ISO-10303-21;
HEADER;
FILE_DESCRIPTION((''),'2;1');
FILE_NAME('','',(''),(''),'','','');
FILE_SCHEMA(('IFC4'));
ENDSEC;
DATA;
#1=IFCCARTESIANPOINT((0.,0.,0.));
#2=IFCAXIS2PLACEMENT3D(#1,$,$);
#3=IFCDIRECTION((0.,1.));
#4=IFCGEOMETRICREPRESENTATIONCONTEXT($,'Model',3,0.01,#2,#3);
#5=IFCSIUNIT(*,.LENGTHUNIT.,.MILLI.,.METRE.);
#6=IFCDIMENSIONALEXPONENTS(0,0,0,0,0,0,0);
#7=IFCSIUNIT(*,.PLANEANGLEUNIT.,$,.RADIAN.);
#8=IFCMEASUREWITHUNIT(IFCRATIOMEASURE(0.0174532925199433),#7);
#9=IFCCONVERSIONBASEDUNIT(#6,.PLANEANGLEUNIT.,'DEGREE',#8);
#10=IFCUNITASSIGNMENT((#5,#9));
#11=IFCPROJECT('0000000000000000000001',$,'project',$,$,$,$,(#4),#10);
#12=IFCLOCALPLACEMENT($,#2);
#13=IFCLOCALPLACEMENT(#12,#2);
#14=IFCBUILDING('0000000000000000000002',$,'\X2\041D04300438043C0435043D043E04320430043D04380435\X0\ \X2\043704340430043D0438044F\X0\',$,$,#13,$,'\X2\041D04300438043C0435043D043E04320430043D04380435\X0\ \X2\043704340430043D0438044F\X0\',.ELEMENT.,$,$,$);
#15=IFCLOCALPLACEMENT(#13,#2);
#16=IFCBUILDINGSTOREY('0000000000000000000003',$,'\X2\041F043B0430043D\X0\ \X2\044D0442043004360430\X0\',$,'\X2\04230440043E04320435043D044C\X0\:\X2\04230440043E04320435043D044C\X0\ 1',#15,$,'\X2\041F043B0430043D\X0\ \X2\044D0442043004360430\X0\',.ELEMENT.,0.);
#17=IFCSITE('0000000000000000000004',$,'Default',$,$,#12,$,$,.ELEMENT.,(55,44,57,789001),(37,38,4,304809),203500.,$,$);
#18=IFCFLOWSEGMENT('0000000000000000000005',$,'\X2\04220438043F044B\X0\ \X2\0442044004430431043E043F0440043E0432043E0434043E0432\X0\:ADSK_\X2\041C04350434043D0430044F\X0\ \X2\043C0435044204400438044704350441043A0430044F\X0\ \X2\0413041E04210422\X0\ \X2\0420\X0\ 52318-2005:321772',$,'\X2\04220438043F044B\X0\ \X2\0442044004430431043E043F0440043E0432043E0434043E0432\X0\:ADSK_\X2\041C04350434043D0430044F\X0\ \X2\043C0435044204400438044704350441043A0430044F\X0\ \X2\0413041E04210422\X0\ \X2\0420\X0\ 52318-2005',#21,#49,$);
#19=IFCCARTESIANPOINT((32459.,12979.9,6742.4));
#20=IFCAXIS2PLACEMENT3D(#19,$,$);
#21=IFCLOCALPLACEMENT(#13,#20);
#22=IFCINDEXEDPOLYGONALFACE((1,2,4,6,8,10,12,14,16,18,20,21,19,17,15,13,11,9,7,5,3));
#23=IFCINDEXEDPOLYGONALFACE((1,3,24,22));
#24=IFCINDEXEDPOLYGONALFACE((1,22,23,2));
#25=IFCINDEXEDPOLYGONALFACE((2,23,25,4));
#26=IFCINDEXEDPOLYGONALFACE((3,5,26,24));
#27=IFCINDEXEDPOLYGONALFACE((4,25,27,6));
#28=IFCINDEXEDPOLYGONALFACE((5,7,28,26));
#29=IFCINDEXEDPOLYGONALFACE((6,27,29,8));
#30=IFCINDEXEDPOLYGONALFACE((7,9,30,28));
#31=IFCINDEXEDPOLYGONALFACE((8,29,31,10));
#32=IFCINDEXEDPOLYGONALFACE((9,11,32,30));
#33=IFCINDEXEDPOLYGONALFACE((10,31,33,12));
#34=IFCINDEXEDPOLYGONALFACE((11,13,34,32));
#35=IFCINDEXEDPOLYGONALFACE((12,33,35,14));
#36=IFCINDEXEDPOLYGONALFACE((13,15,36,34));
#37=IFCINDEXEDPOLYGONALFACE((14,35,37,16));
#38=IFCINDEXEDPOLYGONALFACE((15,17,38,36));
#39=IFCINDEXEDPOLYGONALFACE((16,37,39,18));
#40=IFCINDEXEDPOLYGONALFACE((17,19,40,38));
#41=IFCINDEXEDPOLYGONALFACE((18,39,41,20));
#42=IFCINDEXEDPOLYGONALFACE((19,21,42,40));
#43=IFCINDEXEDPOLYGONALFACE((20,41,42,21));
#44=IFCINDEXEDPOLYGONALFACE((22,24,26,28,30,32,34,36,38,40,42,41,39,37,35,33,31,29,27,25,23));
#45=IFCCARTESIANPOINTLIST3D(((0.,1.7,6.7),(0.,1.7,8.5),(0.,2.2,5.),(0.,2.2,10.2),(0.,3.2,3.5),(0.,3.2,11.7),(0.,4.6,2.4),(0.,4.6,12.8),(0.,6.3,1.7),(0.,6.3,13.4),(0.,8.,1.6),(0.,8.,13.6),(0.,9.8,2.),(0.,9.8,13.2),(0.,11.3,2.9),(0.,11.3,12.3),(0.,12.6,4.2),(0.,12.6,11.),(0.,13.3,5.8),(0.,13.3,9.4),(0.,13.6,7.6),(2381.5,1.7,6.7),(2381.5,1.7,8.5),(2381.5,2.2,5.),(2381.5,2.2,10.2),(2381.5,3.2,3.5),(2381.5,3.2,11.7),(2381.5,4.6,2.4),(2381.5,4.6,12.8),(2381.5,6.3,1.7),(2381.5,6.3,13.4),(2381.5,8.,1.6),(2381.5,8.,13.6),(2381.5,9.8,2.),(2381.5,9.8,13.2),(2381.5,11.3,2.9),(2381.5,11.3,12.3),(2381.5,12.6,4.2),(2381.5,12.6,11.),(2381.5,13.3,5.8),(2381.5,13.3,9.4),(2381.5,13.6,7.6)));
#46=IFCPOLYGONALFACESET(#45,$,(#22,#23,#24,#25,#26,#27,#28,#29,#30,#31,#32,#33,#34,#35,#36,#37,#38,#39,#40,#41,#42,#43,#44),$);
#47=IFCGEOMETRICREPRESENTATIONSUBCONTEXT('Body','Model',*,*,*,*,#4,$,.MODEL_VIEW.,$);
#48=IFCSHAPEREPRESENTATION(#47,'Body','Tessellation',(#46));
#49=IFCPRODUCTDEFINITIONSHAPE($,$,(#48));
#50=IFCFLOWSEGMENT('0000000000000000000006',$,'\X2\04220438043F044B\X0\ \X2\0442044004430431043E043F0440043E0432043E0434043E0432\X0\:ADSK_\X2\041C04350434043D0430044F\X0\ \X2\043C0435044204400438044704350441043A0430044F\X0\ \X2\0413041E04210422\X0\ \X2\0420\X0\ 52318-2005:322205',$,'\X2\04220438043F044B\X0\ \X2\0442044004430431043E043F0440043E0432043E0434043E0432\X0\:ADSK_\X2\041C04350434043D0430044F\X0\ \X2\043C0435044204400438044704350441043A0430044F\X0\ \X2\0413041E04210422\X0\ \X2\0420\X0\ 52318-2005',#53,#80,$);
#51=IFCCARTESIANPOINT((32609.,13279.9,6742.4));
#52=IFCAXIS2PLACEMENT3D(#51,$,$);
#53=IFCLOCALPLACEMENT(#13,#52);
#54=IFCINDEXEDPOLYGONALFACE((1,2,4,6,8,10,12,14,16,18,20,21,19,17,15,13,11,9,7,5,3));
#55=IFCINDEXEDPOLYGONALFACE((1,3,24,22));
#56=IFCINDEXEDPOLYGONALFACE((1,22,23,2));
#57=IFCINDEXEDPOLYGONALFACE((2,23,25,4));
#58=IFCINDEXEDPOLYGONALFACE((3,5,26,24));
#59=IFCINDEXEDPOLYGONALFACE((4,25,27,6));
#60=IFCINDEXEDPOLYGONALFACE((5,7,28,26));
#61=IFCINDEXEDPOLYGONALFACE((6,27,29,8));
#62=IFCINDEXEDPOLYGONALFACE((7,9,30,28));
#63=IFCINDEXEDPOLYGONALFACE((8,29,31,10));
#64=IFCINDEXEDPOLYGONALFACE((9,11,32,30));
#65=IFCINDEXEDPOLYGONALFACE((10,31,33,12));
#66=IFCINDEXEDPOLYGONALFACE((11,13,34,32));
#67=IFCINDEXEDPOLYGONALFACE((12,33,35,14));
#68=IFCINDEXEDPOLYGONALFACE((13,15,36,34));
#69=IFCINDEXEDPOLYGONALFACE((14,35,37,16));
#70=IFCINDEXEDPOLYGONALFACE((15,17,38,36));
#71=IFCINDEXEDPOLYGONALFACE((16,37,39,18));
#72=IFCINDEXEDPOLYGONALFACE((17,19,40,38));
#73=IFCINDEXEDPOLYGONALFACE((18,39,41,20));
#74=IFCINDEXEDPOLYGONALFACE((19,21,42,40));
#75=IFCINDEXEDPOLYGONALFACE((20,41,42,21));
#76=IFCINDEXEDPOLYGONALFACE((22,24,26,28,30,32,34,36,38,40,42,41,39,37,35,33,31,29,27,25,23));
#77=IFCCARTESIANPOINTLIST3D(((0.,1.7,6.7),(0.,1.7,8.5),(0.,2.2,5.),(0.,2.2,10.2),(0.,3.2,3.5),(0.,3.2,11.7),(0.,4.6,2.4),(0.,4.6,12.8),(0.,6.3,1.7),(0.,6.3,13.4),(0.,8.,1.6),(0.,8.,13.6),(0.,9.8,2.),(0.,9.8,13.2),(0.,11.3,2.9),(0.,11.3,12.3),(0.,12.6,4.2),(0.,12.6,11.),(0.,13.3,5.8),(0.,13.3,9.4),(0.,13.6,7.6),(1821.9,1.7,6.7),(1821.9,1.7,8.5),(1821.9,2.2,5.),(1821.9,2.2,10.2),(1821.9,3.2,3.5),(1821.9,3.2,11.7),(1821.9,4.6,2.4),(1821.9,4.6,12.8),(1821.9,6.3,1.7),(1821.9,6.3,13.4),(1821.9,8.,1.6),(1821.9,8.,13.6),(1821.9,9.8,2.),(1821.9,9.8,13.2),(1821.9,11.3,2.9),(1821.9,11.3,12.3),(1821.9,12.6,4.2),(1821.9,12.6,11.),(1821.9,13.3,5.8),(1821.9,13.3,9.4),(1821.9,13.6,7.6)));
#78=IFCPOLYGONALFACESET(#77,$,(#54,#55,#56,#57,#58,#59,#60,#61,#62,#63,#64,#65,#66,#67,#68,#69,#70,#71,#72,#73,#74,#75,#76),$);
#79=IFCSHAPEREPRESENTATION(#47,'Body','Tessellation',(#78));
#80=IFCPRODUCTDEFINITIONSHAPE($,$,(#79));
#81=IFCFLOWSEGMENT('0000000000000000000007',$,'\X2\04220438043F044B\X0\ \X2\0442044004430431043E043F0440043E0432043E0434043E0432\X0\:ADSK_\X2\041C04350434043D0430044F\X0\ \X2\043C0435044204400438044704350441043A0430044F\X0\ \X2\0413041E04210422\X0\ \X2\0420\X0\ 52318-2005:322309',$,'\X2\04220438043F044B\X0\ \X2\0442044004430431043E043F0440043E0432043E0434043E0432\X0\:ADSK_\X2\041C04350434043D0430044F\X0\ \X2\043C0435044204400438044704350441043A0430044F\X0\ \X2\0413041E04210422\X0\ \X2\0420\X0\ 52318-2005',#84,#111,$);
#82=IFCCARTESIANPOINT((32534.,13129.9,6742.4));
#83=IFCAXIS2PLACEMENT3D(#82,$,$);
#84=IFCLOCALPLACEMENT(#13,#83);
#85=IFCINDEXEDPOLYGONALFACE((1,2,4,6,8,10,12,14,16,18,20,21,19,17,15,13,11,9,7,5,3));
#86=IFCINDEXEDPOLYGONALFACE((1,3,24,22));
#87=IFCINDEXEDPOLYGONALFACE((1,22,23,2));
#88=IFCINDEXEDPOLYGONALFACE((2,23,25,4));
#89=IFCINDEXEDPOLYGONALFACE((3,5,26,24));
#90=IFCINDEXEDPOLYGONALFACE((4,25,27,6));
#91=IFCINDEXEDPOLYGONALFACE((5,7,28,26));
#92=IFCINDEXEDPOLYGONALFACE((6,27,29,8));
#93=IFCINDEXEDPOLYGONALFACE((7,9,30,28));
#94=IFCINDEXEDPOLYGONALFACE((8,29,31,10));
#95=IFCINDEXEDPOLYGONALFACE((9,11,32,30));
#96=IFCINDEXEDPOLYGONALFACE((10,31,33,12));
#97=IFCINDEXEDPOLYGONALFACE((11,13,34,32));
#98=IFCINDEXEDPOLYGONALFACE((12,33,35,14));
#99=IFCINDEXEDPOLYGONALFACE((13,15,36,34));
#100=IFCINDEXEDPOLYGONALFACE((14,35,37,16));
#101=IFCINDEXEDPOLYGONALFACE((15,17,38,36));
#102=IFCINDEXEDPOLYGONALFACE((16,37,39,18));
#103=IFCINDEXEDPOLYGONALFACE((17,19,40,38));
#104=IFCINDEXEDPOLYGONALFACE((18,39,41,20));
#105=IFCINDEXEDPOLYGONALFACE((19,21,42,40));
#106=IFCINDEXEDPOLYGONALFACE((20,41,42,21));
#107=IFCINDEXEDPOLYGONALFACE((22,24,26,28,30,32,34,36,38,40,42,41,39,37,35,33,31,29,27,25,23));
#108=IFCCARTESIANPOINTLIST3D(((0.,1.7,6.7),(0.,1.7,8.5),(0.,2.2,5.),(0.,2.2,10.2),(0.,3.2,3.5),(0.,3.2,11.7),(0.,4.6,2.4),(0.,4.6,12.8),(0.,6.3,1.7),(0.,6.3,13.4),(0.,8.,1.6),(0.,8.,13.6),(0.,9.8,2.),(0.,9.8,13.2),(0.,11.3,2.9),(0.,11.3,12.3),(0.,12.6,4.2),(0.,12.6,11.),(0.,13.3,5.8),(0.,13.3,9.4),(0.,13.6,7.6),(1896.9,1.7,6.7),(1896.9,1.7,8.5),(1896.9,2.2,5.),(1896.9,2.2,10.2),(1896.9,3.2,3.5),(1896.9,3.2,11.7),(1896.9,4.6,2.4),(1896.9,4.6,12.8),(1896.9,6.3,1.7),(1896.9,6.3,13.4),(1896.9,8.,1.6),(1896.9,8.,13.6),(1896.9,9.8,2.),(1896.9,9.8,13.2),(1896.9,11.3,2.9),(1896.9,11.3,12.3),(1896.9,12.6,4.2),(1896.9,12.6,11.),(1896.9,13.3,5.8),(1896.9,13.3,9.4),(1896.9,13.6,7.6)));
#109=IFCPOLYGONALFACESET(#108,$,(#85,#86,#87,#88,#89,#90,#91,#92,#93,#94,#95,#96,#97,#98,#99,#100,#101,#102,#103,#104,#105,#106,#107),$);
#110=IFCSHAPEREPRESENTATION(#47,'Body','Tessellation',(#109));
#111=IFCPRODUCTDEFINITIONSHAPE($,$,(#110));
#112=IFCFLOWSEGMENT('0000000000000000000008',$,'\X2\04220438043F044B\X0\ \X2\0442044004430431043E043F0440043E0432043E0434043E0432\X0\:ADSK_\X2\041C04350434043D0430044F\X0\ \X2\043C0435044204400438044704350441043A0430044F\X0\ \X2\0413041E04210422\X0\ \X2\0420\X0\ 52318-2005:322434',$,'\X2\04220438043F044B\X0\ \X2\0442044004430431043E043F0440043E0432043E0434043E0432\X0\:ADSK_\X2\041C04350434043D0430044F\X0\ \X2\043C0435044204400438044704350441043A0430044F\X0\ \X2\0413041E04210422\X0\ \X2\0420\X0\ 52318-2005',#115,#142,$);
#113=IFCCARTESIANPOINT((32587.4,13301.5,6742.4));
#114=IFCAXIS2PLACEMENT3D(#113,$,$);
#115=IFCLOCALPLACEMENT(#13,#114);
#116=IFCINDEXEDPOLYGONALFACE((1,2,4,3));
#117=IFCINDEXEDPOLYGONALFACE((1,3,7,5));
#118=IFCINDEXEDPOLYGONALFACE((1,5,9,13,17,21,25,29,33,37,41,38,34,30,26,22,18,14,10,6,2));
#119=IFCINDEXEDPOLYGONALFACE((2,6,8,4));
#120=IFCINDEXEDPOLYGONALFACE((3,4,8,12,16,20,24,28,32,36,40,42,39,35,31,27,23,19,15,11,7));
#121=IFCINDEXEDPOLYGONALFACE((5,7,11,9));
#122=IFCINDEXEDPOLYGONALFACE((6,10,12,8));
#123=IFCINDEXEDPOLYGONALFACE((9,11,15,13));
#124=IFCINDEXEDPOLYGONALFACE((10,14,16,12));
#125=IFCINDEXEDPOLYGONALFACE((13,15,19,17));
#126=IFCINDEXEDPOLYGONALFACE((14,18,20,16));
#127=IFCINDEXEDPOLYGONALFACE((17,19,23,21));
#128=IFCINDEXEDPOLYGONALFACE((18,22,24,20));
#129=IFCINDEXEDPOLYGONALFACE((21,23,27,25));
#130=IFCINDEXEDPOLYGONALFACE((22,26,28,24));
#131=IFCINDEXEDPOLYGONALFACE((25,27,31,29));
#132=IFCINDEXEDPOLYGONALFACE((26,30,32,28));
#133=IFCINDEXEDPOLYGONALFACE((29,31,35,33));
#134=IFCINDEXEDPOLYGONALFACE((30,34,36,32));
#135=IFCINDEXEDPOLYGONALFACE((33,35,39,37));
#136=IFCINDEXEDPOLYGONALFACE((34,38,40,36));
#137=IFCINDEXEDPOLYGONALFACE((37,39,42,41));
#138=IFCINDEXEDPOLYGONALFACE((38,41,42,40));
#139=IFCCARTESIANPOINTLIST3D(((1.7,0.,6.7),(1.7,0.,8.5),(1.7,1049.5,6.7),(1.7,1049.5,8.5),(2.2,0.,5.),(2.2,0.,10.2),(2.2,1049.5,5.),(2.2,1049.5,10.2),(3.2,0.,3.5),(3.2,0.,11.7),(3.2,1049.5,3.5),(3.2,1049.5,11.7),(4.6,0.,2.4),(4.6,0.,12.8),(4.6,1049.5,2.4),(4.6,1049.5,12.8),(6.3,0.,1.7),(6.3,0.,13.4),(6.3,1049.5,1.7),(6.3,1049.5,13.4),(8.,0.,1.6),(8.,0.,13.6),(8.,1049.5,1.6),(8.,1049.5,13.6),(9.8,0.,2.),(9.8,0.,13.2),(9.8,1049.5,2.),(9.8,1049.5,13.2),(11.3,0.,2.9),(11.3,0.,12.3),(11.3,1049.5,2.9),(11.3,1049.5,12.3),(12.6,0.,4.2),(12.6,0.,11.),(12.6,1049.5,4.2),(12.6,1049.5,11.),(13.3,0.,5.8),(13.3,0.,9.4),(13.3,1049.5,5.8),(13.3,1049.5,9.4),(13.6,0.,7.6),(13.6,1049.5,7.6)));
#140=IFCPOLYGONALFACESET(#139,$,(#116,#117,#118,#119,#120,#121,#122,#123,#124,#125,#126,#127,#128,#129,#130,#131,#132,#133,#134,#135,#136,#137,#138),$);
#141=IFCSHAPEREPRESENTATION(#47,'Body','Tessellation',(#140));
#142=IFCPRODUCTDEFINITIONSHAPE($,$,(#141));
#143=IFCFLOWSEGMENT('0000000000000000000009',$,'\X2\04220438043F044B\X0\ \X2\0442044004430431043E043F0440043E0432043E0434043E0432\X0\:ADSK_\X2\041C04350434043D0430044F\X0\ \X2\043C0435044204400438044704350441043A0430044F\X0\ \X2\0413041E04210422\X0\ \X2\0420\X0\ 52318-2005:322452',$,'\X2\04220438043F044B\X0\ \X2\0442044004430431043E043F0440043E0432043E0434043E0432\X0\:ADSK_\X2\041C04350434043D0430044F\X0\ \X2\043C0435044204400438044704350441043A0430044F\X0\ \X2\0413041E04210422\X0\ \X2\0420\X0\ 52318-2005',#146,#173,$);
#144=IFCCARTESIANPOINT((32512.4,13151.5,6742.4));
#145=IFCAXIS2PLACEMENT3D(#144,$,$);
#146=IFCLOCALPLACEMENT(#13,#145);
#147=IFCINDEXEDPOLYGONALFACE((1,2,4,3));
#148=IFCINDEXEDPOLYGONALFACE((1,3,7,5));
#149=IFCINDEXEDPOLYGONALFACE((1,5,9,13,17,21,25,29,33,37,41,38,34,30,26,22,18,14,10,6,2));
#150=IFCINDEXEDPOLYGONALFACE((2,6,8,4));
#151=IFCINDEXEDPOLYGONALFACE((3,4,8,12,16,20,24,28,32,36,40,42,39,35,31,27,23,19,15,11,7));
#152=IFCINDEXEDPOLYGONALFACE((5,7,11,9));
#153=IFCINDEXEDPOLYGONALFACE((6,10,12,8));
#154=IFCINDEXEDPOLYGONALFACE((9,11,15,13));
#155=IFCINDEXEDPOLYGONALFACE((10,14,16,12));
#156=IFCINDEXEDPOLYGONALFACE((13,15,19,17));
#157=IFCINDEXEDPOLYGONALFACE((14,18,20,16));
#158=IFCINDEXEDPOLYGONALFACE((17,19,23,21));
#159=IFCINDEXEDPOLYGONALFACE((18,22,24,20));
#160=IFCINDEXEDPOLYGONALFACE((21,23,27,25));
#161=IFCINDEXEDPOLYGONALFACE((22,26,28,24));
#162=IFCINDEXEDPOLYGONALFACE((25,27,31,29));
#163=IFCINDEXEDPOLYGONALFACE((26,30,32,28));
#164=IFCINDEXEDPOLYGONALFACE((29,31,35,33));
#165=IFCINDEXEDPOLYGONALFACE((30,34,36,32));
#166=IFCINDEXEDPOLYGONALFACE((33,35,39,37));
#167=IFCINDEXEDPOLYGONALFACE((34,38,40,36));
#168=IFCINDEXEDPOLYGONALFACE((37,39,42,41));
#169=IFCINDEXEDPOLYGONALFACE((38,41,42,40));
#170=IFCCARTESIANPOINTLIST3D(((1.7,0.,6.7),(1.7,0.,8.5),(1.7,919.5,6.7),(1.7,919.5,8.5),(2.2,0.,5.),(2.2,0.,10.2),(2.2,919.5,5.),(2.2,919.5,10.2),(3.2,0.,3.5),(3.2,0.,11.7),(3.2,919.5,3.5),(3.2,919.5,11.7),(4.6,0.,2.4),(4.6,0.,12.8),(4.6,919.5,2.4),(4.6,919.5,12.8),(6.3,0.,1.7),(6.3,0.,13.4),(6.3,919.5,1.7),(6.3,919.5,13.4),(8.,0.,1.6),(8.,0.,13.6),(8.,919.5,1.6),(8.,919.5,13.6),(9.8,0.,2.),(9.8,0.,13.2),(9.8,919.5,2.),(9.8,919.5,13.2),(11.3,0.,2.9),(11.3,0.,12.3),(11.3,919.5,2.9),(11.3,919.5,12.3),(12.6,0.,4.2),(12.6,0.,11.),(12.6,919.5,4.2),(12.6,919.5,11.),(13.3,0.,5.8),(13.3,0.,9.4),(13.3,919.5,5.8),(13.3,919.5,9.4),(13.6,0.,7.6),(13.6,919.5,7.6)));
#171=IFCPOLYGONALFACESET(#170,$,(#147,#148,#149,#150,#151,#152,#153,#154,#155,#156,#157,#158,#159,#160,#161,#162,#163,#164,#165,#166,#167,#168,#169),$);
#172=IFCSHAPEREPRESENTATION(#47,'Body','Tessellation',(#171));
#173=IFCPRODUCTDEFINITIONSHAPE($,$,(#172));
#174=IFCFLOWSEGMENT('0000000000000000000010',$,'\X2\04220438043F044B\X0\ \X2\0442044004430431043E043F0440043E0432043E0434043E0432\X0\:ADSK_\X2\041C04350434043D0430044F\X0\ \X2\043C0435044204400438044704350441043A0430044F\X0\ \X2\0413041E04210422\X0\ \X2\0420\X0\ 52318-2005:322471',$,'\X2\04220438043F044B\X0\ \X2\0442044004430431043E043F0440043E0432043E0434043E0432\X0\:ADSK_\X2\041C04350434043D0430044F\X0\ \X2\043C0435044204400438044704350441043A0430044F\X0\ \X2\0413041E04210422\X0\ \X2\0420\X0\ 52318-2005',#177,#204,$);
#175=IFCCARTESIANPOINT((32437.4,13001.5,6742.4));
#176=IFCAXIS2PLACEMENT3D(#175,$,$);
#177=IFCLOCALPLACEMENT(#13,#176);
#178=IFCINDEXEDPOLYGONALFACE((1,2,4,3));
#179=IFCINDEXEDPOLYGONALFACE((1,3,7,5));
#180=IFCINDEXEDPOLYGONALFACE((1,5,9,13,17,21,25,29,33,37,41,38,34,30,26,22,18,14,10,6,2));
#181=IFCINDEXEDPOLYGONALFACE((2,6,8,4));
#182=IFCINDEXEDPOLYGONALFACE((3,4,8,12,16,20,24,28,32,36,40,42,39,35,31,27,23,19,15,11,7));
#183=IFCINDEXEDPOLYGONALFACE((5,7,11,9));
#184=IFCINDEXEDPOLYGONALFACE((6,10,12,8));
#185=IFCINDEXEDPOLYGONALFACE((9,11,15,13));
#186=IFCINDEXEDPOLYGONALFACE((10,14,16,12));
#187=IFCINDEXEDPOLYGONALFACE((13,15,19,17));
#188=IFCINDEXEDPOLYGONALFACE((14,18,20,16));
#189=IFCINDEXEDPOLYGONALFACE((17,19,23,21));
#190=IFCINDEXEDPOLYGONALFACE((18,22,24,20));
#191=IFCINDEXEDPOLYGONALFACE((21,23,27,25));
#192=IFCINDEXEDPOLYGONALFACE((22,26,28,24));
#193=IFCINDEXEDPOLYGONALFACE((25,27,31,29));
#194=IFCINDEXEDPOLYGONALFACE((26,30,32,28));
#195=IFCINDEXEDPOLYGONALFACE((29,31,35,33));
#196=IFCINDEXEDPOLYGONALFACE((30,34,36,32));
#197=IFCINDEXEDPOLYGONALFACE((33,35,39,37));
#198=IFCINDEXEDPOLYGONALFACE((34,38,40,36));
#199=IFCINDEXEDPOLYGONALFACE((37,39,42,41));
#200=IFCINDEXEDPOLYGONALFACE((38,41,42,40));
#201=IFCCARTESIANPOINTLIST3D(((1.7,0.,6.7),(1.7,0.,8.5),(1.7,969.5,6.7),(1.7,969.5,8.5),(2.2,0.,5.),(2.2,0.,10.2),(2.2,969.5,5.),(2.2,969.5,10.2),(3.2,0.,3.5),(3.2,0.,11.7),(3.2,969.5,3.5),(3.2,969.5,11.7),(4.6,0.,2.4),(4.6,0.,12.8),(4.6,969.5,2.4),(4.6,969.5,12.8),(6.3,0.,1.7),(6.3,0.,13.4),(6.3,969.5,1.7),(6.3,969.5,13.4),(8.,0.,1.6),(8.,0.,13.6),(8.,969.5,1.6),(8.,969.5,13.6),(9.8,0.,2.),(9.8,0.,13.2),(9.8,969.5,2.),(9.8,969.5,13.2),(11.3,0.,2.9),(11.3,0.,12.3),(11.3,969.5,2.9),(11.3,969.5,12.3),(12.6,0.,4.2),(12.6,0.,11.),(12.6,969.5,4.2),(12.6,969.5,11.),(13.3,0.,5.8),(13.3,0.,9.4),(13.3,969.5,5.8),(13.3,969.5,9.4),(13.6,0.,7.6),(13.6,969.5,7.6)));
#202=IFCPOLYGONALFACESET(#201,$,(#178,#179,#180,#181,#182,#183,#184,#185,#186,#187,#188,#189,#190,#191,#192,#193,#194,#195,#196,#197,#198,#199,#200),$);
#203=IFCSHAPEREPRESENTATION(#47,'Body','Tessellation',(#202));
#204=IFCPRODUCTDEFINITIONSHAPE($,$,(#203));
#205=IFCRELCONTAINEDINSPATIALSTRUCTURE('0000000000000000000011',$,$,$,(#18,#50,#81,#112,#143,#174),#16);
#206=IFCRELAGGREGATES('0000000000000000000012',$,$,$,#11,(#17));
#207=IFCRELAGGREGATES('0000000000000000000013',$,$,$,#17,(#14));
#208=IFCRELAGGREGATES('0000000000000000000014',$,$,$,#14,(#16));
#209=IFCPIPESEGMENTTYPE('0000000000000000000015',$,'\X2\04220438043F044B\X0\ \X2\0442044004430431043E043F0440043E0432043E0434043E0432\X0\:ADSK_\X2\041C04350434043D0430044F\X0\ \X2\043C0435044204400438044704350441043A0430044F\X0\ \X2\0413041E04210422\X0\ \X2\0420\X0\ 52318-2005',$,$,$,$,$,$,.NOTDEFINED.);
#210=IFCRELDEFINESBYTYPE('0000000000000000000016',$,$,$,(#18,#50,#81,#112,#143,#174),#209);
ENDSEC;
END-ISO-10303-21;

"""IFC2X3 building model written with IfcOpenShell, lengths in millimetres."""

from ifc_helpers import new_model, entity, si_unit, converted_unit, direction, frame, frame_2d, origin, origin_2d_with_axis, place, context, subcontext, project, spatial, circle, extrude, type_object, element, save


model = new_model("IFC2X3")

# Units and contexts
model_context = context("Model", 3, precision=0.01, world=origin(), true_north=direction((0.0, 1.0)))
body_context = subcontext(model_context, "Body", "Model", "MODEL_VIEW")
ifc_project = project(units=[si_unit("LENGTHUNIT", "METRE", prefix="MILLI"), converted_unit("PLANEANGLEUNIT", "DEGREE", entity("IfcRatioMeasure", 0.0174532925199433), si_unit("PLANEANGLEUNIT", "RADIAN"), dimensions=[0, 0, 0, 0, 0, 0, 0])], contexts=[model_context])

# Site, building, storey
site_placement = place(None, frame((0.0, 0.0, 0.0)))
site = spatial("IfcSite", under=ifc_project, at=site_placement, Name="Default", CompositionType="ELEMENT", RefLatitude=(55, 44, 57, 789001), RefLongitude=(37, 38, 4, 304809), RefElevation=203500.0)
building_placement = place(site_placement, origin())
building = spatial("IfcBuilding", under=site, at=building_placement, Name="Наименование здания", LongName="Наименование здания", CompositionType="ELEMENT")
storey_placement = place(building_placement, origin())
storey = spatial("IfcBuildingStorey", under=building, at=storey_placement, Name="План этажа", ObjectType="Уровень:Уровень 1", LongName="План этажа", CompositionType="ELEMENT", Elevation=0.0)

# Flow segments
pipe_segment_type = type_object("IfcPipeSegmentType", Name="Типы трубопроводов:ADSK_Медная метрическая ГОСТ Р 52318-2005", PredefinedType="NOTDEFINED")
flow_segment_1_placement = place(building_placement, frame((32459.0, 12979.9, 6742.4)))
element("IfcFlowSegment", 1, at=flow_segment_1_placement, inside=storey, type_object=pipe_segment_type, Name="Типы трубопроводов:ADSK_Медная метрическая ГОСТ Р 52318-2005:321772", ObjectType="Типы трубопроводов:ADSK_Медная метрическая ГОСТ Р 52318-2005", context=body_context, shape_type="SweptSolid", body=[
    extrude(circle(Radius=6.0, at=frame_2d((0.0, 0.0), x_axis=(1.0, 0.0))), frame((0.0, 7.6, 7.6), z_axis=(1.0, 0.0, 0.0), x_axis=(0.0, 1.0, 0.0)), (0.0, 0.0, 1.0), 2381.5),
])
flow_segment_2_placement = place(building_placement, frame((32609.0, 13279.9, 6742.4)))
element("IfcFlowSegment", 2, at=flow_segment_2_placement, inside=storey, type_object=pipe_segment_type, Name="Типы трубопроводов:ADSK_Медная метрическая ГОСТ Р 52318-2005:322205", ObjectType="Типы трубопроводов:ADSK_Медная метрическая ГОСТ Р 52318-2005", context=body_context, shape_type="SweptSolid", body=[
    extrude(circle(Radius=6.0, at=frame_2d((0.0, 0.0), x_axis=(1.0, 0.0))), frame((0.0, 7.6, 7.6), z_axis=(1.0, 0.0, 0.0), x_axis=(0.0, 1.0, 0.0)), (0.0, 0.0, 1.0), 1821.9),
])
flow_segment_3_placement = place(building_placement, frame((32534.0, 13129.9, 6742.4)))
element("IfcFlowSegment", 3, at=flow_segment_3_placement, inside=storey, type_object=pipe_segment_type, Name="Типы трубопроводов:ADSK_Медная метрическая ГОСТ Р 52318-2005:322309", ObjectType="Типы трубопроводов:ADSK_Медная метрическая ГОСТ Р 52318-2005", context=body_context, shape_type="SweptSolid", body=[
    extrude(circle(Radius=6.0, at=frame_2d((0.0, 0.0), x_axis=(1.0, 0.0))), frame((0.0, 7.6, 7.6), z_axis=(1.0, 0.0, 0.0), x_axis=(0.0, 1.0, 0.0)), (0.0, 0.0, 1.0), 1896.9),
])
flow_segment_4_placement = place(building_placement, frame((32587.4, 13301.5, 6742.4)))
element("IfcFlowSegment", 4, at=flow_segment_4_placement, inside=storey, type_object=pipe_segment_type, Name="Типы трубопроводов:ADSK_Медная метрическая ГОСТ Р 52318-2005:322434", ObjectType="Типы трубопроводов:ADSK_Медная метрическая ГОСТ Р 52318-2005", context=body_context, shape_type="SweptSolid", body=[
    extrude(circle(Radius=6.0, at=origin_2d_with_axis()), frame((7.6, 0.0, 7.6), z_axis=(0.0, 1.0, 0.0), x_axis=(1.0, 0.0, 0.0)), (0.0, 0.0, 1.0), 1049.5),
])
flow_segment_5_placement = place(building_placement, frame((32512.4, 13151.5, 6742.4)))
element("IfcFlowSegment", 5, at=flow_segment_5_placement, inside=storey, type_object=pipe_segment_type, Name="Типы трубопроводов:ADSK_Медная метрическая ГОСТ Р 52318-2005:322452", ObjectType="Типы трубопроводов:ADSK_Медная метрическая ГОСТ Р 52318-2005", context=body_context, shape_type="SweptSolid", body=[
    extrude(circle(Radius=6.0, at=frame_2d((0.0, 0.0), x_axis=(1.0, 0.0))), frame((7.6, 0.0, 7.6), z_axis=(0.0, 1.0, 0.0), x_axis=(1.0, 0.0, 0.0)), (0.0, 0.0, 1.0), 919.5),
])
flow_segment_6_placement = place(building_placement, frame((32437.4, 13001.5, 6742.4)))
element("IfcFlowSegment", 6, at=flow_segment_6_placement, inside=storey, type_object=pipe_segment_type, Name="Типы трубопроводов:ADSK_Медная метрическая ГОСТ Р 52318-2005:322471", ObjectType="Типы трубопроводов:ADSK_Медная метрическая ГОСТ Р 52318-2005", context=body_context, shape_type="SweptSolid", body=[
    extrude(circle(Radius=6.0, at=origin_2d_with_axis()), frame((7.6, 0.0, 7.6), z_axis=(0.0, 1.0, 0.0), x_axis=(1.0, 0.0, 0.0)), (0.0, 0.0, 1.0), 969.5),
])

save(model, "model.ifc")
